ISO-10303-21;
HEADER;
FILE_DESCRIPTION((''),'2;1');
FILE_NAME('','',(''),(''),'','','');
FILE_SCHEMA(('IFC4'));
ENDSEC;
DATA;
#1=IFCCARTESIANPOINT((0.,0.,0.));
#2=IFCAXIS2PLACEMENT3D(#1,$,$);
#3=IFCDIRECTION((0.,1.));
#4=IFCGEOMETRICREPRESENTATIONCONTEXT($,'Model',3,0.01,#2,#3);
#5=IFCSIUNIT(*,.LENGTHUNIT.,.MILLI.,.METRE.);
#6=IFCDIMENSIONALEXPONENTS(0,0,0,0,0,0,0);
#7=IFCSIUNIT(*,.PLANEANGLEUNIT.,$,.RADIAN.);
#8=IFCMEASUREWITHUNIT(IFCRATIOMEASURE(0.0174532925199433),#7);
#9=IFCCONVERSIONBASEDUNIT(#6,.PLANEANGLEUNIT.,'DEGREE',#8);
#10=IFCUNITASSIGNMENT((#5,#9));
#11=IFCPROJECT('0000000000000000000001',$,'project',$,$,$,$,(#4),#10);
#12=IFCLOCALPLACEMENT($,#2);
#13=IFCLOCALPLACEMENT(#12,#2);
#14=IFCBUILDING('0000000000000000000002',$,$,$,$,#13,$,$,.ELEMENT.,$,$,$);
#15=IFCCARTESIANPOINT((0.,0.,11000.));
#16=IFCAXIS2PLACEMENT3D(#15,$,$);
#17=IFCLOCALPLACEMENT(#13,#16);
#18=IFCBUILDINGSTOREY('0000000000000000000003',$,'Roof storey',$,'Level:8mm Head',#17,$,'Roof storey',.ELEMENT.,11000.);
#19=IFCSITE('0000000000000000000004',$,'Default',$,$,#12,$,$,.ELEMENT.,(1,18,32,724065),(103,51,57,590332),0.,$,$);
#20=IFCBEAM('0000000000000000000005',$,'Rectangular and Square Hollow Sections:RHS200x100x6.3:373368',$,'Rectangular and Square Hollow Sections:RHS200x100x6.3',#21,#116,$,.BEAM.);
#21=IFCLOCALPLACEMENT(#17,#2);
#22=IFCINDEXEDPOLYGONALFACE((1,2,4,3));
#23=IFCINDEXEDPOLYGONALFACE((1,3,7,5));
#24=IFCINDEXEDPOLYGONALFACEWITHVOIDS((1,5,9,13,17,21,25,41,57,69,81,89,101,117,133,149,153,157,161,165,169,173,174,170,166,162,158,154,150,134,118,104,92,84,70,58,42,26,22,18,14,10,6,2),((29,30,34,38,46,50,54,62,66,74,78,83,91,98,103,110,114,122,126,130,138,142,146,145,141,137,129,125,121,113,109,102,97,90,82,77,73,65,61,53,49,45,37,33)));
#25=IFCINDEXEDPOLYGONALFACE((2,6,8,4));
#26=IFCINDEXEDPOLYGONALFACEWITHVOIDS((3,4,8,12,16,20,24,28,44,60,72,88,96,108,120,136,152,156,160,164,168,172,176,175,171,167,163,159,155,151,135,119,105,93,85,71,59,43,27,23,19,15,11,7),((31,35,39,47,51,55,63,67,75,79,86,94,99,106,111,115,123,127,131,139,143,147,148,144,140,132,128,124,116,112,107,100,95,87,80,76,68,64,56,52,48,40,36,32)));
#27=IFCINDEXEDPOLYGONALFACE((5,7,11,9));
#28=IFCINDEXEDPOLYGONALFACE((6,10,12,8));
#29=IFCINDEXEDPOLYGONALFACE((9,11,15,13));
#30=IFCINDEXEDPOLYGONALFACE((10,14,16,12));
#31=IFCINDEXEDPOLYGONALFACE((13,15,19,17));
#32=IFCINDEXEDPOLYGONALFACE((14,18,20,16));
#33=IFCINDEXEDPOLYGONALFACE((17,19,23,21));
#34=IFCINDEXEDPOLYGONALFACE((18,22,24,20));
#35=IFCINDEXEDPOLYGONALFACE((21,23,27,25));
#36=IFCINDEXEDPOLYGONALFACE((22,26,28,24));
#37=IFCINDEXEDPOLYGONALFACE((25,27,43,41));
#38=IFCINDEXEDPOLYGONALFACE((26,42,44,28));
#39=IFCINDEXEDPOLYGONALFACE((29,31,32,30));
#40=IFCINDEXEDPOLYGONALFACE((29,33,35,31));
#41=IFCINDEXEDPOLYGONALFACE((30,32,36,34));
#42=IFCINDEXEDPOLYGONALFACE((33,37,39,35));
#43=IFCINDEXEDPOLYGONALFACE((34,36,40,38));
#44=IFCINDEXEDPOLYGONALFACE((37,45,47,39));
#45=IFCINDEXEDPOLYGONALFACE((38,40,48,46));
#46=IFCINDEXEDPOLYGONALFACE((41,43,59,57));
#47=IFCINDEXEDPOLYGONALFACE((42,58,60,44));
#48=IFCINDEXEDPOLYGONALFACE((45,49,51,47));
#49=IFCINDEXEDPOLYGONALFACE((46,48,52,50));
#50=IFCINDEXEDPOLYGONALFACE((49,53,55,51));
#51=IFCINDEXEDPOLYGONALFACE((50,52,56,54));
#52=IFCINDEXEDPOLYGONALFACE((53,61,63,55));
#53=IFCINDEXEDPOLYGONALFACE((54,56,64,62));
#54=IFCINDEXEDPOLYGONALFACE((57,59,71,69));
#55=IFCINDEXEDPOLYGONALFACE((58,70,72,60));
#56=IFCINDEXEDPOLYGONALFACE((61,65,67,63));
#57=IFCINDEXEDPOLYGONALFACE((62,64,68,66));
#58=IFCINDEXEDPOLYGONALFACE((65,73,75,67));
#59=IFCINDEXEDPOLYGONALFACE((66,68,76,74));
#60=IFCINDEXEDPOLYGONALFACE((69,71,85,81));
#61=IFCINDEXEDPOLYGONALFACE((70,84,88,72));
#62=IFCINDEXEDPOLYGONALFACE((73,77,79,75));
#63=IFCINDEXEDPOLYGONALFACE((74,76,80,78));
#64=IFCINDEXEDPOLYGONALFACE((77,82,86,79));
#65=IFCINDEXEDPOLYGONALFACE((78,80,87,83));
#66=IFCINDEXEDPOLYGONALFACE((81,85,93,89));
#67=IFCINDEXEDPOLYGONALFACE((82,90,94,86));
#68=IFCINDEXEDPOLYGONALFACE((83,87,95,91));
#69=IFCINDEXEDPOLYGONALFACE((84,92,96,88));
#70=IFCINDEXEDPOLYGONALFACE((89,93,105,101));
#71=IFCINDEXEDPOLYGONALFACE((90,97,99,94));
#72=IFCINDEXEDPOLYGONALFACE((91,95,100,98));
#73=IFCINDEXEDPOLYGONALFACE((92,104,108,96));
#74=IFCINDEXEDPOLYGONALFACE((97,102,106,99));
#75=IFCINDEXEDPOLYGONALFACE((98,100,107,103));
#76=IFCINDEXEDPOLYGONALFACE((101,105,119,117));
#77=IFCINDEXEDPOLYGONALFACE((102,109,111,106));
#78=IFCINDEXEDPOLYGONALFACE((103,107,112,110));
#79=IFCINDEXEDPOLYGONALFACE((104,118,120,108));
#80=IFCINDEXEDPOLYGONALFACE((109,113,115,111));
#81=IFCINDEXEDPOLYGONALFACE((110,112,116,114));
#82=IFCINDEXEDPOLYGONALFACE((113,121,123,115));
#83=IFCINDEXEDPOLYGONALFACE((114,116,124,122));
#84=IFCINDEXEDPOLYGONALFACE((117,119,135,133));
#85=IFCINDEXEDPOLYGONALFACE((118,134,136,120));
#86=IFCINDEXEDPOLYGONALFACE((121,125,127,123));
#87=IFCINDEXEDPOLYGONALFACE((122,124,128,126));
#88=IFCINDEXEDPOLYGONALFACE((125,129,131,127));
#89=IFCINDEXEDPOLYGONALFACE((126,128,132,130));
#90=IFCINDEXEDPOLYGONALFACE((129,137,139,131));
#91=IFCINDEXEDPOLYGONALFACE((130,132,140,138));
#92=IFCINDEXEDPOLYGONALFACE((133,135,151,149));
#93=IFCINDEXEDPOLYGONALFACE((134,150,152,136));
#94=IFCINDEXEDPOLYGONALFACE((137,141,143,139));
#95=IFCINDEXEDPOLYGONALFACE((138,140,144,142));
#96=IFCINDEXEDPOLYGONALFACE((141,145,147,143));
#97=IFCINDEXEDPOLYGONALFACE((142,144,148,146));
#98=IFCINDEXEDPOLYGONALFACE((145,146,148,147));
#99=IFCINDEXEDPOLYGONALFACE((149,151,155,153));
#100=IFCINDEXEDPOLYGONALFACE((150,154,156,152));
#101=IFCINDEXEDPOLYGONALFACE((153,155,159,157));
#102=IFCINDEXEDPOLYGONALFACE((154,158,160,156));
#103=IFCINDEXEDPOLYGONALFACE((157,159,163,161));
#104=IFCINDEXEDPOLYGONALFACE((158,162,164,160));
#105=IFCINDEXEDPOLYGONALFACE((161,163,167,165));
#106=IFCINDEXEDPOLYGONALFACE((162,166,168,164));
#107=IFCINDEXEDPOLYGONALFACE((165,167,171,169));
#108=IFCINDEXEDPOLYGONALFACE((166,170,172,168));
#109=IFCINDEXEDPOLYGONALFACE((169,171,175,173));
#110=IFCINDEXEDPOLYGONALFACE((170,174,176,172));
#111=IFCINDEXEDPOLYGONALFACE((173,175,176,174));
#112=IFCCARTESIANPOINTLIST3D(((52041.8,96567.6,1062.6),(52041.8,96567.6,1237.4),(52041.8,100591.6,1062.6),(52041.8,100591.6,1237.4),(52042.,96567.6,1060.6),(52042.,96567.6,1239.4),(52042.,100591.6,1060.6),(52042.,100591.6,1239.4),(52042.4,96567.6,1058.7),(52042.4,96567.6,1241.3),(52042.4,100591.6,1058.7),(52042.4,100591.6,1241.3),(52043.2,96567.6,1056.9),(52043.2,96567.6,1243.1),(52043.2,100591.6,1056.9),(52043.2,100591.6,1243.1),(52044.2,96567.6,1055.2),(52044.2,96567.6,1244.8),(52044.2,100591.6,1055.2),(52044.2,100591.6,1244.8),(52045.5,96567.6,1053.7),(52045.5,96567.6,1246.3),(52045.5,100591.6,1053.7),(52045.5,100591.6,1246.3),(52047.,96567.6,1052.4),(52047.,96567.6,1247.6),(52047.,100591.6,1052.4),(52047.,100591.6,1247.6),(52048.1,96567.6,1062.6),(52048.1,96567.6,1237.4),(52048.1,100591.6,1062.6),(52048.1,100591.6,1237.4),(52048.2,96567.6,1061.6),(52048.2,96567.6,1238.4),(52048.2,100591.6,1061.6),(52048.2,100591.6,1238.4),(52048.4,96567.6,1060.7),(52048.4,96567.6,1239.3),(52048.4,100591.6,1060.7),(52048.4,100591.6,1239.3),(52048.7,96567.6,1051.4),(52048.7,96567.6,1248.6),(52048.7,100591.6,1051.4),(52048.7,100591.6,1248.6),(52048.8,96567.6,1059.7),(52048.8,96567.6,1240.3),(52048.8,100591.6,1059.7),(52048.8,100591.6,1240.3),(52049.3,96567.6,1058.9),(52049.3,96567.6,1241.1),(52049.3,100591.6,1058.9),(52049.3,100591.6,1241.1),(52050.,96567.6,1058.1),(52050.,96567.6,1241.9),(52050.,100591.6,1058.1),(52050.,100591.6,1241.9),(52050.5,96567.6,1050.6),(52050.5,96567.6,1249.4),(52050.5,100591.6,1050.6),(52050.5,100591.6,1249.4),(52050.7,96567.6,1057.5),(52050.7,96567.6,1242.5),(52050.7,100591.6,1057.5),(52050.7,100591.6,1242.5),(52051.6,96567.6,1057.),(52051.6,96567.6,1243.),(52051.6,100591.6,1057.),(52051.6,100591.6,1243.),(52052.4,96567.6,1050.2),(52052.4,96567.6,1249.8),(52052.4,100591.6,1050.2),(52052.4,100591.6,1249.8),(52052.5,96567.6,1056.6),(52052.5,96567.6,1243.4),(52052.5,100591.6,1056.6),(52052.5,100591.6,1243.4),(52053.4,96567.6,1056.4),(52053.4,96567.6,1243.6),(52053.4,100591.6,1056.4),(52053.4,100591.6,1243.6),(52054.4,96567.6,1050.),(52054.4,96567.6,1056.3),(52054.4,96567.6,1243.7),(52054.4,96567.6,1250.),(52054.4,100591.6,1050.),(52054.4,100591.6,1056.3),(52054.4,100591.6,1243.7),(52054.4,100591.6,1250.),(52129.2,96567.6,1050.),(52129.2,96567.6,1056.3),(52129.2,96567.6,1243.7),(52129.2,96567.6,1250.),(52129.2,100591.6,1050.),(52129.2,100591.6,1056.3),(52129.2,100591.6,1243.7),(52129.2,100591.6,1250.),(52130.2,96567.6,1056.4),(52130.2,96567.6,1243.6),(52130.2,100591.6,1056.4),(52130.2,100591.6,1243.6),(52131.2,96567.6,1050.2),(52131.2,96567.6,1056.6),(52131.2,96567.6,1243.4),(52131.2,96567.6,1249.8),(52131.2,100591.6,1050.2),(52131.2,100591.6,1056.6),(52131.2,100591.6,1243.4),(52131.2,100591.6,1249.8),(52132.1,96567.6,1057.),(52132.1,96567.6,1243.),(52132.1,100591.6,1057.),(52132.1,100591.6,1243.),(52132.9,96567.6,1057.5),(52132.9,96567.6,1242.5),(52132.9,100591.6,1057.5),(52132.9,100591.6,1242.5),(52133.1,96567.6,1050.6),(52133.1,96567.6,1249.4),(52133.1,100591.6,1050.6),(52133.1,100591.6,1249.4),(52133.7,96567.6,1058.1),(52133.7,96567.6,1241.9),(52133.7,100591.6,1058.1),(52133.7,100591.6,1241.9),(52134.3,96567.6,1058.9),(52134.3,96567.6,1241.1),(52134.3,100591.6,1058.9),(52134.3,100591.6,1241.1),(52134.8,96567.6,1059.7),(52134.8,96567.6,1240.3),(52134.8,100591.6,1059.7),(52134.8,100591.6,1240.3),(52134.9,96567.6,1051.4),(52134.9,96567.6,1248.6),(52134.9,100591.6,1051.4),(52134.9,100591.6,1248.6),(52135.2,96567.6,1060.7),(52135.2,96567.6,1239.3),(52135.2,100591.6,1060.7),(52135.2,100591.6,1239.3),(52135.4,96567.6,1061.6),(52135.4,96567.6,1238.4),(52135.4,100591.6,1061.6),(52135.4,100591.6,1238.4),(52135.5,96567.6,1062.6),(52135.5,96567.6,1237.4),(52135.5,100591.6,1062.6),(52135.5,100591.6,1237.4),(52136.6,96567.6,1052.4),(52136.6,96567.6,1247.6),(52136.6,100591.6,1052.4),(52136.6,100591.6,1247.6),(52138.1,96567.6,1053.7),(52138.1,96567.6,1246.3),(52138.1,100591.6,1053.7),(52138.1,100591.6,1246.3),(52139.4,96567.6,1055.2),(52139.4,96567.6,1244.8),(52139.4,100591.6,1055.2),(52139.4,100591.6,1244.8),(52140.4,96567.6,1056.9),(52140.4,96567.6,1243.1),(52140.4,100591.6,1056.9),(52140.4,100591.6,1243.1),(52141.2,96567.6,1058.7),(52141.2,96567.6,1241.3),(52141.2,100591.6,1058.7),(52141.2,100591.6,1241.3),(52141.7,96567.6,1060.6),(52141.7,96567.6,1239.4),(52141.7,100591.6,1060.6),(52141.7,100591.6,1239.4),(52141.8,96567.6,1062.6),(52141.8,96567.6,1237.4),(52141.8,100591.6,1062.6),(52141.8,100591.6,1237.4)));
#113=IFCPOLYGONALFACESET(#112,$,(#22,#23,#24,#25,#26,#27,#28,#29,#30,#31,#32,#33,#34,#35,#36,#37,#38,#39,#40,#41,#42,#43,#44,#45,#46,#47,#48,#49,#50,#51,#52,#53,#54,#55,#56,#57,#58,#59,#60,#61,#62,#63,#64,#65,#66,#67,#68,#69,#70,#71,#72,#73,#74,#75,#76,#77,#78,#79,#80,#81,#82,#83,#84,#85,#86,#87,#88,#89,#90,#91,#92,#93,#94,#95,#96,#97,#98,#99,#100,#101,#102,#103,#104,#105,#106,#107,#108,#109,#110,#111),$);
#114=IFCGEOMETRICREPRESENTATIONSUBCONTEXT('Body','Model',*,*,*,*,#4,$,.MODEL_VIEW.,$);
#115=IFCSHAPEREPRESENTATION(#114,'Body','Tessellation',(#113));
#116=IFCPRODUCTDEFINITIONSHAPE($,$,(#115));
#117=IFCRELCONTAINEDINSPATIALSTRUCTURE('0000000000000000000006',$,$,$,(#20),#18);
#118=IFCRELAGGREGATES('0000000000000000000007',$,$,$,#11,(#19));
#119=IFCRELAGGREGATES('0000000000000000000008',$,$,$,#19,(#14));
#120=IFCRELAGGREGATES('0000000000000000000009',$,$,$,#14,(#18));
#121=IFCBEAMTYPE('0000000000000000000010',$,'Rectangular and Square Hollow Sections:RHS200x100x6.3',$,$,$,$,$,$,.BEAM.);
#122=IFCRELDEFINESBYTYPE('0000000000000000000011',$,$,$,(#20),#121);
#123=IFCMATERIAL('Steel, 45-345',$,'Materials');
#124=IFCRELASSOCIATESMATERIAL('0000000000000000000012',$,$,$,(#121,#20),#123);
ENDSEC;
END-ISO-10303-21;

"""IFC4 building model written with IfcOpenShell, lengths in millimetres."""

from ifc_helpers import new_model, entity, si_unit, converted_unit, direction, frame, origin, place, context, subcontext, project, spatial, indexed_curve, outline, extrude, source, transform, mapped, material, type_object, type_shapes, element, save


model = new_model("IFC4")

# Units and contexts
model_context = context("Model", 3, precision=0.01, world=origin(), true_north=direction((0.0, 1.0)))
body_context = subcontext(model_context, "Body", "Model", "MODEL_VIEW")
ifc_project = project(units=[si_unit("LENGTHUNIT", "METRE", prefix="MILLI"), converted_unit("PLANEANGLEUNIT", "DEGREE", entity("IfcRatioMeasure", 0.0174532925199433), si_unit("PLANEANGLEUNIT", "RADIAN"), dimensions=[0, 0, 0, 0, 0, 0, 0])], contexts=[model_context])

# Site, building, storey
site_placement = place(None, origin())
site = spatial("IfcSite", under=ifc_project, at=site_placement, Name="Default", CompositionType="ELEMENT", RefLatitude=(1, 18, 32, 724065), RefLongitude=(103, 51, 57, 590332), RefElevation=0.0)
building_placement = place(site_placement, origin())
building = spatial("IfcBuilding", under=site, at=building_placement, CompositionType="ELEMENT")
storey_placement = place(building_placement, frame((0.0, 0.0, 11000.0)))
storey = spatial("IfcBuildingStorey", under=building, at=storey_placement, Name="Roof storey", ObjectType="Level:8mm Head", LongName="Roof storey", CompositionType="ELEMENT", Elevation=11000.0)

# Shared definitions
ifc_material = material(Name="Steel, 45-345", Category="Materials")

# Beam
beam_type_1 = type_object("IfcBeamType", Name="Rectangular and Square Hollow Sections:RHS200x100x6.3", PredefinedType="BEAM", material=ifc_material)
shared_shape_1 = source(origin(), body_context, "Body", "SweptSolid", [
    extrude(outline(indexed_curve([(87.4, -50.0), (89.4, -49.8), (91.3, -49.4), (93.1, -48.6), (94.8, -47.6), (96.3, -46.3), (97.6, -44.8), (98.6, -43.1), (99.4, -41.3), (99.8, -39.4), (100.0, -37.4), (100.0, 37.4), (99.8, 39.4), (99.4, 41.3), (98.6, 43.1), (97.6, 44.8), (96.3, 46.3), (94.8, 47.6), (93.1, 48.6), (91.3, 49.4), (89.4, 49.8), (87.4, 50.0), (-87.4, 50.0), (-89.4, 49.8), (-91.3, 49.4), (-93.1, 48.6), (-94.8, 47.6), (-96.3, 46.3), (-97.6, 44.8), (-98.6, 43.1), (-99.4, 41.3), (-99.8, 39.4), (-100.0, 37.4), (-100.0, -37.4), (-99.8, -39.4), (-99.4, -41.3), (-98.6, -43.1), (-97.6, -44.8), (-96.3, -46.3), (-94.8, -47.6), (-93.1, -48.6), (-91.3, -49.4), (-89.4, -49.8), (-87.4, -50.0), (87.4, -50.0)], self_intersect=False), holes=[indexed_curve([(93.7, 37.4), (93.7, -37.4), (93.6, -38.4), (93.4, -39.3), (93.0, -40.3), (92.5, -41.1), (91.9, -41.9), (91.1, -42.5), (90.3, -43.0), (89.3, -43.4), (88.4, -43.6), (87.4, -43.7), (-87.4, -43.7), (-88.4, -43.6), (-89.3, -43.4), (-90.3, -43.0), (-91.1, -42.5), (-91.9, -41.9), (-92.5, -41.1), (-93.0, -40.3), (-93.4, -39.3), (-93.6, -38.4), (-93.7, -37.4), (-93.7, 37.4), (-93.6, 38.4), (-93.4, 39.3), (-93.0, 40.3), (-92.5, 41.1), (-91.9, 41.9), (-91.1, 42.5), (-90.3, 43.0), (-89.3, 43.4), (-88.4, 43.6), (-87.4, 43.7), (87.4, 43.7), (88.4, 43.6), (89.3, 43.4), (90.3, 43.0), (91.1, 42.5), (91.9, 41.9), (92.5, 41.1), (93.0, 40.3), (93.4, 39.3), (93.6, 38.4), (93.7, 37.4)], self_intersect=False)]), frame((-2012.0, 0.0, 0.0), z_axis=(1.0, 0.0, 0.0), x_axis=(0.0, 0.0, 1.0)), (0.0, 0.0, 1.0), 4024.0),
])
type_shapes(beam_type_1, [shared_shape_1])
for number, where, z_axis, x_axis, name in (
    (1, (52091.8, 98579.6, 1150.0), (0.0, 0.0, 1.0), (0.0, 1.0, 0.0), "Rectangular and Square Hollow Sections:RHS200x100x6.3:373368"),
):
    element("IfcBeam", number, at=place(storey_placement, frame(where, z_axis=z_axis, x_axis=x_axis)), inside=storey, type_object=beam_type_1, material=ifc_material, Name=name, ObjectType="Rectangular and Square Hollow Sections:RHS200x100x6.3", PredefinedType="BEAM", context=body_context, shape_type="MappedRepresentation", body=[
        mapped(shared_shape_1, transform((0.0, 0.0, 0.0), scale=1.0)),
    ])

save(model, "model.ifc")
